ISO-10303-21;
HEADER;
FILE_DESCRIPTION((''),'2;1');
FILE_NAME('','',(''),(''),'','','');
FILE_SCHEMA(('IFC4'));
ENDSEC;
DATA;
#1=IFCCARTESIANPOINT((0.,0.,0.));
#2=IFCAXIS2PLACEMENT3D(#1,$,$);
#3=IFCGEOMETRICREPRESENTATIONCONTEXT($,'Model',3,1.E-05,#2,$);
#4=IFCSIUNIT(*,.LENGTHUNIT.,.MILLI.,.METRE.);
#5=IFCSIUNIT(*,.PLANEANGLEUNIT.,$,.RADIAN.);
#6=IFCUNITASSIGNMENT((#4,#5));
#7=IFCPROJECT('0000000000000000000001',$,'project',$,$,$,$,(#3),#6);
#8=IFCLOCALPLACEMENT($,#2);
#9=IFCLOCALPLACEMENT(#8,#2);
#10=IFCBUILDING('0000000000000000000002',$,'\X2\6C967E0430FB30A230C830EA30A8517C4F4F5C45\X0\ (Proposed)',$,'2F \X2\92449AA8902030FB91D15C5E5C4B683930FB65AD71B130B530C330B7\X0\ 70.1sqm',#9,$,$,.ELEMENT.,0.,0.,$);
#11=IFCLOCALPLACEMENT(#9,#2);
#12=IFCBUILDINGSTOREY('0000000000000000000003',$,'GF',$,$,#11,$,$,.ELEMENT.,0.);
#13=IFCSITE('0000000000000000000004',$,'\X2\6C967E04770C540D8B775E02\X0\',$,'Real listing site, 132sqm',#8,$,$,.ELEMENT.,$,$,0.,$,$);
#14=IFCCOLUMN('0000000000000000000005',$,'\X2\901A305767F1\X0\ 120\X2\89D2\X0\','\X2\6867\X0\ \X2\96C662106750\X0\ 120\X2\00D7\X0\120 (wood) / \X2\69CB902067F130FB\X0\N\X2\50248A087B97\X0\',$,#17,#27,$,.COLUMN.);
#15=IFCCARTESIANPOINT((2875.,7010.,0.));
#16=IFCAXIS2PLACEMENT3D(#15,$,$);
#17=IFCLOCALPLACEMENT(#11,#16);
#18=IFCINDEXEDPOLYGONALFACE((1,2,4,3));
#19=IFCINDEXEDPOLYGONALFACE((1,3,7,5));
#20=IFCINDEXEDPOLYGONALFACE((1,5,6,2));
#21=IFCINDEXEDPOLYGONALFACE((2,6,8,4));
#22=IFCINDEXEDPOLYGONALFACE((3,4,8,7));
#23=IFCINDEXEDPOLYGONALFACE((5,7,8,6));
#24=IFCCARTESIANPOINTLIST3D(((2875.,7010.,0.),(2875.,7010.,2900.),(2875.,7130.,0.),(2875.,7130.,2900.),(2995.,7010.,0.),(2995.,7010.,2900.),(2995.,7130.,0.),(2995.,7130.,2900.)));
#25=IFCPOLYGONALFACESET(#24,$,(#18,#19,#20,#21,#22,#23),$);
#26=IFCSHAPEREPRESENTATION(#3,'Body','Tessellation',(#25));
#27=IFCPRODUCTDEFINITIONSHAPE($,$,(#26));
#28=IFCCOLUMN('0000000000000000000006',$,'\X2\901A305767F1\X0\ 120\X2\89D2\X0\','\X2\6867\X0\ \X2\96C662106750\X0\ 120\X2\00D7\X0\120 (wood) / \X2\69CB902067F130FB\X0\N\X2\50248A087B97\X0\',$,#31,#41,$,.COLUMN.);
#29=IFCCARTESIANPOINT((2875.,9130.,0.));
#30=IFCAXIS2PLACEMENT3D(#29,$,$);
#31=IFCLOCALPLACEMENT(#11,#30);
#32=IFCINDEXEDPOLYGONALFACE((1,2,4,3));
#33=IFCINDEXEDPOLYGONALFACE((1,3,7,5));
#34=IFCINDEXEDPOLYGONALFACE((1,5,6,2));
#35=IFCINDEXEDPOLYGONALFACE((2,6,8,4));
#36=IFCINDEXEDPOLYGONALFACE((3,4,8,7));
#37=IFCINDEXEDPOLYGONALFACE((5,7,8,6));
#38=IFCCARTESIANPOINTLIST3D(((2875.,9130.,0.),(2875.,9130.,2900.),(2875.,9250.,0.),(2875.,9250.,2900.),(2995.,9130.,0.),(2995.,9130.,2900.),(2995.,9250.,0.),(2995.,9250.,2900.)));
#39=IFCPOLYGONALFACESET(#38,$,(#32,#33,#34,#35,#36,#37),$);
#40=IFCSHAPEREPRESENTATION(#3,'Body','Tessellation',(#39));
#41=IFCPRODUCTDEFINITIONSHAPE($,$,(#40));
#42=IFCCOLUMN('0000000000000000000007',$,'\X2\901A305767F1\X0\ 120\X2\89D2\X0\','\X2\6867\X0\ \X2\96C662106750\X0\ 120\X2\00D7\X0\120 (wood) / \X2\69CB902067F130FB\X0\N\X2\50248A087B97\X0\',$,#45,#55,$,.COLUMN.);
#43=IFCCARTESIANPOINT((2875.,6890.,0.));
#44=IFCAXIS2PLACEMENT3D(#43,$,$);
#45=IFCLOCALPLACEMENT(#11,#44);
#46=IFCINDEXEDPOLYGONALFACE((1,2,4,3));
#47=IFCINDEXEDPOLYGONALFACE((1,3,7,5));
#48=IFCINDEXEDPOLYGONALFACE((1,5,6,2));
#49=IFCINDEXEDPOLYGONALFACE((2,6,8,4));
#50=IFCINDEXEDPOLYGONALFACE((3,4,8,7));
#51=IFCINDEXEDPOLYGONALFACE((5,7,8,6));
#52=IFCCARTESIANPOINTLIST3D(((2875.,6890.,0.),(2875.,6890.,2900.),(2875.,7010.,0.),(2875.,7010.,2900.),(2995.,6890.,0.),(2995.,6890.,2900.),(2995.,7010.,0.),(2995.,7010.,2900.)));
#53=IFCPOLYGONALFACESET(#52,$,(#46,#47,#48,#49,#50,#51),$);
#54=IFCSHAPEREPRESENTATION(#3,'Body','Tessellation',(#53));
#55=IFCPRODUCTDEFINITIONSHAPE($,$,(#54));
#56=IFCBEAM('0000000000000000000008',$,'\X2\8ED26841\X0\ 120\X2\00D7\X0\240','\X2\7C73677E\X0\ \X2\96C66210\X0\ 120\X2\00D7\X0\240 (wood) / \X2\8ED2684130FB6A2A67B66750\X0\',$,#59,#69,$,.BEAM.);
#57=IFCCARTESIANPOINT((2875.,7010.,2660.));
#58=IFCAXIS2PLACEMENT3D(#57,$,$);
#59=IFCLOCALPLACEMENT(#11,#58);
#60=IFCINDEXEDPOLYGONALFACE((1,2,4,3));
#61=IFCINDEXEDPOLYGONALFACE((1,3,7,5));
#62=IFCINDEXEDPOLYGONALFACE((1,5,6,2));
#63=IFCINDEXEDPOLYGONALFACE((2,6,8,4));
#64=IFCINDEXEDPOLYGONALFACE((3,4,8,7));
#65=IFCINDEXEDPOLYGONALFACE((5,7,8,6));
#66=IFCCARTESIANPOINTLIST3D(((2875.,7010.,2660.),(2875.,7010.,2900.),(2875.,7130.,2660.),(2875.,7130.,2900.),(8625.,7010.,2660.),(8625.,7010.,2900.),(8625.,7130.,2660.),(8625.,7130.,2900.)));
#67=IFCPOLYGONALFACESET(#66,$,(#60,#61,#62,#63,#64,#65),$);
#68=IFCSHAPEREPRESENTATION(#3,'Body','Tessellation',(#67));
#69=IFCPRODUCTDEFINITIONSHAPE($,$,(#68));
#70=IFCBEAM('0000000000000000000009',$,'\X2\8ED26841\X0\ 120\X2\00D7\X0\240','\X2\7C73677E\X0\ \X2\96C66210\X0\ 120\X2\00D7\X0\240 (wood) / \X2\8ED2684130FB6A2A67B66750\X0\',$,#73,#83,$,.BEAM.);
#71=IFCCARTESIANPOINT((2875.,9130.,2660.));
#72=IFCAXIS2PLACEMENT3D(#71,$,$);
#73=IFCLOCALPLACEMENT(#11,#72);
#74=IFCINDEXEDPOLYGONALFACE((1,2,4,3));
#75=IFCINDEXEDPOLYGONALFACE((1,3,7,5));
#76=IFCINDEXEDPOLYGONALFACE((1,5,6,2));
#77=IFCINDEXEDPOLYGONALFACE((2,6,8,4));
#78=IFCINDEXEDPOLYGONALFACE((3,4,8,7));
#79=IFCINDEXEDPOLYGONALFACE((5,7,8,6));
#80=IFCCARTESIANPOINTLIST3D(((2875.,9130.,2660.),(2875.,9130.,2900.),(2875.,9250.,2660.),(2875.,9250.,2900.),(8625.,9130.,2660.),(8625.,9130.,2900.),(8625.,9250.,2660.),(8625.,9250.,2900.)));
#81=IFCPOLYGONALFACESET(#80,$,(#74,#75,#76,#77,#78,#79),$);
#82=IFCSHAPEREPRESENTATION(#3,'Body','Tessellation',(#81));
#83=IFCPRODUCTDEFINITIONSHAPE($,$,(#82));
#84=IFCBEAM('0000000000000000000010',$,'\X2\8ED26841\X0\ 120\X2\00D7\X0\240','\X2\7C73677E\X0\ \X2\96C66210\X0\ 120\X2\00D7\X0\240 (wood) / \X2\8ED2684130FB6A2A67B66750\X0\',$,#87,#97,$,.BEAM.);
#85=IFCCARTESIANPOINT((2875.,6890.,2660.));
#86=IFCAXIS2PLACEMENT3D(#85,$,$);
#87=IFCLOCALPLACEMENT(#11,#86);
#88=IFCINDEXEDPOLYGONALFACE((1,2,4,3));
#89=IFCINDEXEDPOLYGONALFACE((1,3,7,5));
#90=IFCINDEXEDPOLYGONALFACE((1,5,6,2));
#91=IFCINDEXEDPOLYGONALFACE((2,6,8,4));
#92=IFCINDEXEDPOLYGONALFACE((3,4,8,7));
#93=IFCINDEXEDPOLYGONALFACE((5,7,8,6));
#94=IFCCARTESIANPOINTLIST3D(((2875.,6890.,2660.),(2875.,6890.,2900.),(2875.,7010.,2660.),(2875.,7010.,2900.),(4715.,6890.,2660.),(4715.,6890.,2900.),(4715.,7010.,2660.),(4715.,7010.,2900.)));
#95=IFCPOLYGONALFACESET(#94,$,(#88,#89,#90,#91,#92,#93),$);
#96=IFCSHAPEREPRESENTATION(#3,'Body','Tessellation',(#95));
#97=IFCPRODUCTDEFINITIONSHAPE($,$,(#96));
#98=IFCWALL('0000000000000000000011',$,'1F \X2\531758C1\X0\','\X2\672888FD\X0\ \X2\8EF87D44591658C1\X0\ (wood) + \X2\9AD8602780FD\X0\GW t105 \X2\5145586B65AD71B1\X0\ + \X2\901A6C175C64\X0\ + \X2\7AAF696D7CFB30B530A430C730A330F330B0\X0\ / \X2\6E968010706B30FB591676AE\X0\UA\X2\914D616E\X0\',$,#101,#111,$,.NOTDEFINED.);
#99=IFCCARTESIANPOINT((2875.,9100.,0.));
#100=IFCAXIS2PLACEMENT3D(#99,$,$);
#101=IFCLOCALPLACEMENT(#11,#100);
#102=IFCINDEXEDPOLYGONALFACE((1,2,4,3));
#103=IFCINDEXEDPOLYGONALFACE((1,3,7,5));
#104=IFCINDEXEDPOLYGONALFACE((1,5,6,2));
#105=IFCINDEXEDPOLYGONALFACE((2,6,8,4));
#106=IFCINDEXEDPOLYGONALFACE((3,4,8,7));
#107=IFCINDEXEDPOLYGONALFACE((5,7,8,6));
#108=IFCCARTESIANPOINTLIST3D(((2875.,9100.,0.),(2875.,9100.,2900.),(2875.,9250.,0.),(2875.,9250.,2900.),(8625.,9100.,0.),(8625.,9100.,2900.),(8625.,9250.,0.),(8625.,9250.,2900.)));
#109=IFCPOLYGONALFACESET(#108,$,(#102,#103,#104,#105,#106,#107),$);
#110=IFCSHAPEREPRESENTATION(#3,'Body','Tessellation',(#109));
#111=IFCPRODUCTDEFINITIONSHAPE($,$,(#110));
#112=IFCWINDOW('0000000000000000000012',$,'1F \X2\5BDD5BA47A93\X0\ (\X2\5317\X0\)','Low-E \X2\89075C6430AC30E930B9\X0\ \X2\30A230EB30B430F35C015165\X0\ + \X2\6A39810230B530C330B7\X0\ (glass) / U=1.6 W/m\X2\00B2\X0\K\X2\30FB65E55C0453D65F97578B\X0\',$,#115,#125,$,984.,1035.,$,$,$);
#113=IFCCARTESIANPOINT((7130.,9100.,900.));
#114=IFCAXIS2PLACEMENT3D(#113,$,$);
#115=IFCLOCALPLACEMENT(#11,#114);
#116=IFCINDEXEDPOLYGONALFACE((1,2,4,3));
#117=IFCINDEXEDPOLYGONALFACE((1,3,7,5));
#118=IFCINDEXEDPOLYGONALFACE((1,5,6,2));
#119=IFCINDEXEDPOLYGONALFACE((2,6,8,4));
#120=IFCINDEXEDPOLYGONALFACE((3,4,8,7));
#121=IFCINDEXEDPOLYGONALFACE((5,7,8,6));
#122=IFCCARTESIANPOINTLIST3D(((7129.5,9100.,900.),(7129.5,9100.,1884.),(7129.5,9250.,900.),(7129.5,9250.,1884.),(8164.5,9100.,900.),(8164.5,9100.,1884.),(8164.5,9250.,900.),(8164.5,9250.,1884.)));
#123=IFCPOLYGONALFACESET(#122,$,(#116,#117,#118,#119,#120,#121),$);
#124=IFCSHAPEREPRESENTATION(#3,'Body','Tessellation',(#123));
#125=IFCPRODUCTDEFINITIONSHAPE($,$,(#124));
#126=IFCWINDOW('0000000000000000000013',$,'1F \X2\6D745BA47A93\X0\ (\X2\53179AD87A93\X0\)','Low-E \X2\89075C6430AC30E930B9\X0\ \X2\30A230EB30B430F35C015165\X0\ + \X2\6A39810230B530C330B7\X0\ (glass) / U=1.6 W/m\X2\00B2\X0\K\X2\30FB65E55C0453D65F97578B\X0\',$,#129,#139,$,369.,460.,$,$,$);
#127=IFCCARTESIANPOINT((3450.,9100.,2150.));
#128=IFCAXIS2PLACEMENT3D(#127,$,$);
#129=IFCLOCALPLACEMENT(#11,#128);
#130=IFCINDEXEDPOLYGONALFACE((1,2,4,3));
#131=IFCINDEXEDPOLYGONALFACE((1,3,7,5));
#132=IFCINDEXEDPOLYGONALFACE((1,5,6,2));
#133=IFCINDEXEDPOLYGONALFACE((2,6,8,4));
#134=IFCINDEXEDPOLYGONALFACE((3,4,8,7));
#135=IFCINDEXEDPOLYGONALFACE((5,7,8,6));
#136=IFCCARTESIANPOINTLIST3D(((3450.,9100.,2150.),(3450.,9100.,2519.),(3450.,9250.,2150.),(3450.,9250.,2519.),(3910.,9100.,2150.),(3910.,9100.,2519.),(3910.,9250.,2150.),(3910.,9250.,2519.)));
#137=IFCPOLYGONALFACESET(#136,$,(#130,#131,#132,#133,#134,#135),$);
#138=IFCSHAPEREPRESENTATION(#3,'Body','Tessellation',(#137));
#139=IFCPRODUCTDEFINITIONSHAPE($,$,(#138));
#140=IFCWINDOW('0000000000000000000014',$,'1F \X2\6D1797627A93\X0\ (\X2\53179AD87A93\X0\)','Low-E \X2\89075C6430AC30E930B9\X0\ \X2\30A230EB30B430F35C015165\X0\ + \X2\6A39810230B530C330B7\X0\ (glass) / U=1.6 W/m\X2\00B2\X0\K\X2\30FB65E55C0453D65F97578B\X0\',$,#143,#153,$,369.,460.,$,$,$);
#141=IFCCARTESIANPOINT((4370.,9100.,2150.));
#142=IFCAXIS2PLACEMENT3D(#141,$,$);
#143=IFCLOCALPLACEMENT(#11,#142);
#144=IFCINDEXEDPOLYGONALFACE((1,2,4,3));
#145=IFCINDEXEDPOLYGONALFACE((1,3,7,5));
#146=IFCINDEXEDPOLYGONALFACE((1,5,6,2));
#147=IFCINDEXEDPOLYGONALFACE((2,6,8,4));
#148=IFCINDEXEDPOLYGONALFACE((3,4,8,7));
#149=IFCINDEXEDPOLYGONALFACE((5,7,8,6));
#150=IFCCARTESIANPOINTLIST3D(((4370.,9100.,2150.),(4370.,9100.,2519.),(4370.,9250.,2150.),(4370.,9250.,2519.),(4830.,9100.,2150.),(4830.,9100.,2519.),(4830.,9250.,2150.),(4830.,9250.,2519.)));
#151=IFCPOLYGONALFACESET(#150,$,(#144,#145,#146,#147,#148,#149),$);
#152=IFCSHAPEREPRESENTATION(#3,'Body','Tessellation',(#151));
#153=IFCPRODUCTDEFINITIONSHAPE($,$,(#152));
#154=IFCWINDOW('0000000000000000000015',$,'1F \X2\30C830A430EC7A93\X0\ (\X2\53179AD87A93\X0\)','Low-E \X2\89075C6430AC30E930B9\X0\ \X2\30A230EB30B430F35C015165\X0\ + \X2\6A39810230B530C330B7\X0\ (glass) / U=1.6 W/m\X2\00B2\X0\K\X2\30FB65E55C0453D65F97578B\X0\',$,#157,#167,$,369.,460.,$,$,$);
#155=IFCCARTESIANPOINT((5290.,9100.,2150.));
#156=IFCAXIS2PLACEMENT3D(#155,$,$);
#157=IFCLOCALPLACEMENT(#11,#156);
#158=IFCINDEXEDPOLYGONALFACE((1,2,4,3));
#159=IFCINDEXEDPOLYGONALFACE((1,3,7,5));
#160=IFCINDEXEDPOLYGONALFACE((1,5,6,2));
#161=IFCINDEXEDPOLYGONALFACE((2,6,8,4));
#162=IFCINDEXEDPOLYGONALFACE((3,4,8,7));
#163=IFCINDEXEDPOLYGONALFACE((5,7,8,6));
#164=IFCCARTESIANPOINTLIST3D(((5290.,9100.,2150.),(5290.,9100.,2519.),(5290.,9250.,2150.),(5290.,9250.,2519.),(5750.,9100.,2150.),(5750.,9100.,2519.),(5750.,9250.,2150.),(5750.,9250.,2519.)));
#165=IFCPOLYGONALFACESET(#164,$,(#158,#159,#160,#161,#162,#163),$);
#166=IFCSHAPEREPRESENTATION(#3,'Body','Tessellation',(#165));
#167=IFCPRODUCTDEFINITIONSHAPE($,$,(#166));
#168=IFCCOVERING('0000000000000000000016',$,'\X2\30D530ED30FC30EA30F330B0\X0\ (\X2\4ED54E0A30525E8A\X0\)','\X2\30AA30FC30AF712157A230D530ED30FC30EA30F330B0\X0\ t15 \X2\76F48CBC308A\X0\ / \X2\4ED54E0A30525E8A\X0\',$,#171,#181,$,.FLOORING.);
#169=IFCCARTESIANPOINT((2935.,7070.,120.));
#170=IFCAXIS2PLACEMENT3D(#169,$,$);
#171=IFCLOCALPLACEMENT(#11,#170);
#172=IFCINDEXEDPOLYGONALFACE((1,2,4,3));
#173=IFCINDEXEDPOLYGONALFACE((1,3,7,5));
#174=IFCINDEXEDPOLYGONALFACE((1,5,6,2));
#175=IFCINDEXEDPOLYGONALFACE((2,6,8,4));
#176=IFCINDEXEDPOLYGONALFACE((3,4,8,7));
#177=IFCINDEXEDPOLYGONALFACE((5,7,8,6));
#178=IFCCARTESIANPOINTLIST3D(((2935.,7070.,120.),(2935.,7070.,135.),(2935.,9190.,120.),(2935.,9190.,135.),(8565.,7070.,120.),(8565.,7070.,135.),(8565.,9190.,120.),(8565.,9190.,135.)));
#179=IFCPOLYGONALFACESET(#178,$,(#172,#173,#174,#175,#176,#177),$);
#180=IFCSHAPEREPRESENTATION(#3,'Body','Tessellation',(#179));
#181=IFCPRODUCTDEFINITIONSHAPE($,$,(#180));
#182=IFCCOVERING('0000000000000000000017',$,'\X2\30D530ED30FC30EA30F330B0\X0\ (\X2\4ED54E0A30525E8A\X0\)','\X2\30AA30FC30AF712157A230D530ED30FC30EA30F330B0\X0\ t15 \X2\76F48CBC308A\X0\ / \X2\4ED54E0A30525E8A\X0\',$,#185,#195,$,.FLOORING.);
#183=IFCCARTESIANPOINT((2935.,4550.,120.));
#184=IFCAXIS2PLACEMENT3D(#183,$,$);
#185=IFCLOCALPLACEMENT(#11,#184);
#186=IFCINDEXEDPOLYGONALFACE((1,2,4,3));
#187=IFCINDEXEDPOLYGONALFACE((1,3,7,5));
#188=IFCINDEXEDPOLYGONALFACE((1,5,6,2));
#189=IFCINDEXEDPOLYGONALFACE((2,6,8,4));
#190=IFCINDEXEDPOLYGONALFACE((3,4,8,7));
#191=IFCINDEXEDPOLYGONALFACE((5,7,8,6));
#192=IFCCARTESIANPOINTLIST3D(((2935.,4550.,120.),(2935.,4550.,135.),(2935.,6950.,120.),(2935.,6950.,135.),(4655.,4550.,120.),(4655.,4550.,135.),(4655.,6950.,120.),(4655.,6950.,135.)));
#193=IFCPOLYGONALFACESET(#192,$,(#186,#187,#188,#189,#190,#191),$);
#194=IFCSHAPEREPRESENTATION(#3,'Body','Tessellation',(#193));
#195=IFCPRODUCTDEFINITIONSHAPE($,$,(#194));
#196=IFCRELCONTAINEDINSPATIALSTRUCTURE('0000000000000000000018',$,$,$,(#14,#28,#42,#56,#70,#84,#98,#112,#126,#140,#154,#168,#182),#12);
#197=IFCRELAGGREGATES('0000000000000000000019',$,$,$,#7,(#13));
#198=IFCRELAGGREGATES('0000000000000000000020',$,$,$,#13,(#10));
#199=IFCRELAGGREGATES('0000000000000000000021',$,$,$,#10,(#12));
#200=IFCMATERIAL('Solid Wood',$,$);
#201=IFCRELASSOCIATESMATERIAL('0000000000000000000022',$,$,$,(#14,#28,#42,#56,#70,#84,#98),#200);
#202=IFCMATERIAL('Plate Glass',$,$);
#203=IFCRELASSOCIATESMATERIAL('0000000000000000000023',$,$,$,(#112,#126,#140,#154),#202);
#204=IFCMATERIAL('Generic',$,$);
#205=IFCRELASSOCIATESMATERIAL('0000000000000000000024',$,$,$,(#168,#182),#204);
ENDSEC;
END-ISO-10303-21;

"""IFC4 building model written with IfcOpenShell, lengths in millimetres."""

from ifc_helpers import new_model, si_unit, frame, frame_2d, origin, place, context, project, spatial, rectangle, extrude, material, element, fill, save


model = new_model("IFC4")

# Units and contexts
model_context = context("Model", 3, precision=1e-05, world=origin())
ifc_project = project(units=[si_unit("LENGTHUNIT", "METRE", prefix="MILLI"), si_unit("PLANEANGLEUNIT", "RADIAN")], contexts=[model_context])

# Site, building, storey
site_placement = place(None, origin())
site = spatial("IfcSite", under=ifc_project, at=site_placement, Name="沖縄県名護市", ObjectType="Real listing site, 132sqm", CompositionType="ELEMENT", RefElevation=0.0)
building_placement = place(site_placement, origin())
building = spatial("IfcBuilding", under=site, at=building_placement, Name="沖縄・アトリエ兼住居 (Proposed)", ObjectType="2F 鉄骨造・金属屋根・断熱サッシ 70.1sqm", CompositionType="ELEMENT", ElevationOfRefHeight=0.0, ElevationOfTerrain=0.0)
storey_placement = place(building_placement, origin())
storey = spatial("IfcBuildingStorey", under=building, at=storey_placement, Name="GF", CompositionType="ELEMENT", Elevation=0.0)

# Columns
ifc_material_1 = material(Name="Solid Wood")
column_1_placement = place(storey_placement, frame((2875.0, 7010.0, 0.0)))
element("IfcColumn", 1, at=column_1_placement, inside=storey, material=ifc_material_1, Name="通し柱 120角", Description="桧 集成材 120×120 (wood) / 構造柱・N値計算", PredefinedType="COLUMN", context=model_context, shape_type="SweptSolid", body=[
    extrude(rectangle(XDim=120.0, YDim=120.0, at=frame_2d((60.0, 60.0))), frame((2875.0, 7010.0, 0.0)), (0.0, 0.0, 1.0), 2900.0),
])
column_2_placement = place(storey_placement, frame((2875.0, 9130.0, 0.0)))
element("IfcColumn", 2, at=column_2_placement, inside=storey, material=ifc_material_1, Name="通し柱 120角", Description="桧 集成材 120×120 (wood) / 構造柱・N値計算", PredefinedType="COLUMN", context=model_context, shape_type="SweptSolid", body=[
    extrude(rectangle(XDim=120.0, YDim=120.0, at=frame_2d((60.0, 60.0))), frame((2875.0, 9130.0, 0.0)), (0.0, 0.0, 1.0), 2900.0),
])
column_3_placement = place(storey_placement, frame((2875.0, 6890.0, 0.0)))
element("IfcColumn", 3, at=column_3_placement, inside=storey, material=ifc_material_1, Name="通し柱 120角", Description="桧 集成材 120×120 (wood) / 構造柱・N値計算", PredefinedType="COLUMN", context=model_context, shape_type="SweptSolid", body=[
    extrude(rectangle(XDim=120.0, YDim=120.0, at=frame_2d((60.0, 60.0))), frame((2875.0, 6890.0, 0.0)), (0.0, 0.0, 1.0), 2900.0),
])

# Beams
beam_1_placement = place(storey_placement, frame((2875.0, 7010.0, 2660.0)))
element("IfcBeam", 4, at=beam_1_placement, inside=storey, material=ifc_material_1, Name="軒桁 120×240", Description="米松 集成 120×240 (wood) / 軒桁・横架材", PredefinedType="BEAM", context=model_context, shape_type="SweptSolid", body=[
    extrude(rectangle(XDim=5750.0, YDim=120.0, at=frame_2d((2875.0, 60.0))), frame((2875.0, 7010.0, 2660.0)), (0.0, 0.0, 1.0), 240.0),
])
beam_2_placement = place(storey_placement, frame((2875.0, 9130.0, 2660.0)))
element("IfcBeam", 5, at=beam_2_placement, inside=storey, material=ifc_material_1, Name="軒桁 120×240", Description="米松 集成 120×240 (wood) / 軒桁・横架材", PredefinedType="BEAM", context=model_context, shape_type="SweptSolid", body=[
    extrude(rectangle(XDim=5750.0, YDim=120.0, at=frame_2d((2875.0, 60.0))), frame((2875.0, 9130.0, 2660.0)), (0.0, 0.0, 1.0), 240.0),
])
beam_3_placement = place(storey_placement, frame((2875.0, 6890.0, 2660.0)))
element("IfcBeam", 6, at=beam_3_placement, inside=storey, material=ifc_material_1, Name="軒桁 120×240", Description="米松 集成 120×240 (wood) / 軒桁・横架材", PredefinedType="BEAM", context=model_context, shape_type="SweptSolid", body=[
    extrude(rectangle(XDim=1840.0, YDim=120.0, at=frame_2d((920.0, 60.0))), frame((2875.0, 6890.0, 2660.0)), (0.0, 0.0, 1.0), 240.0),
])

# Wall, openings, windows
wall_1_placement = place(storey_placement, frame((2875.0, 9100.0, 0.0)))
wall_1 = element("IfcWall", 7, at=wall_1_placement, inside=storey, material=ifc_material_1, Name="1F 北壁", Description="木製 軸組外壁 (wood) + 高性能GW t105 充填断熱 + 通気層 + 窯業系サイディング / 準耐火・外皮UA配慮", PredefinedType="NOTDEFINED", context=model_context, shape_type="SweptSolid", body=[
    extrude(rectangle(XDim=5750.0, YDim=150.0, at=frame_2d((2875.0, 75.0))), frame((2875.0, 9100.0, 0.0)), (0.0, 0.0, 1.0), 2900.0),
])
opening_1_placement = place(storey_placement, frame((7130.0, 9100.0, 900.0)))
opening_1 = element("IfcOpeningElement", 8, at=opening_1_placement, cuts=wall_1, PredefinedType="NOTDEFINED", context=model_context, shape_type="SweptSolid", body=[
    extrude(rectangle(XDim=1035.0, YDim=150.0, at=frame_2d((517.0, 75.0))), frame((7130.0, 9100.0, 900.0)), (0.0, 0.0, 1.0), 984.0),
])
opening_2_placement = place(storey_placement, frame((3450.0, 9100.0, 2150.0)))
opening_2 = element("IfcOpeningElement", 9, at=opening_2_placement, cuts=wall_1, PredefinedType="NOTDEFINED", context=model_context, shape_type="SweptSolid", body=[
    extrude(rectangle(XDim=460.0, YDim=150.0, at=frame_2d((230.0, 75.0))), frame((3450.0, 9100.0, 2150.0)), (0.0, 0.0, 1.0), 369.0),
])
opening_3_placement = place(storey_placement, frame((4370.0, 9100.0, 2150.0)))
opening_3 = element("IfcOpeningElement", 10, at=opening_3_placement, cuts=wall_1, PredefinedType="NOTDEFINED", context=model_context, shape_type="SweptSolid", body=[
    extrude(rectangle(XDim=460.0, YDim=150.0, at=frame_2d((230.0, 75.0))), frame((4370.0, 9100.0, 2150.0)), (0.0, 0.0, 1.0), 369.0),
])
opening_4_placement = place(storey_placement, frame((5290.0, 9100.0, 2150.0)))
opening_4 = element("IfcOpeningElement", 11, at=opening_4_placement, cuts=wall_1, PredefinedType="NOTDEFINED", context=model_context, shape_type="SweptSolid", body=[
    extrude(rectangle(XDim=460.0, YDim=150.0, at=frame_2d((230.0, 75.0))), frame((5290.0, 9100.0, 2150.0)), (0.0, 0.0, 1.0), 369.0),
])
ifc_material_2 = material(Name="Plate Glass")
window_1_placement = place(storey_placement, frame((7130.0, 9100.0, 900.0)))
window_1 = element("IfcWindow", 12, at=window_1_placement, inside=storey, material=ifc_material_2, Name="1F 寝室窓 (北)", Description="Low-E 複層ガラス アルゴン封入 + 樹脂サッシ (glass) / U=1.6 W/m²K・日射取得型", OverallHeight=984.0, OverallWidth=1035.0, context=model_context, shape_type="SweptSolid", body=[
    extrude(rectangle(XDim=1035.0, YDim=150.0, at=frame_2d((517.0, 75.0))), frame((7130.0, 9100.0, 900.0)), (0.0, 0.0, 1.0), 984.0),
])
fill(opening_1, window_1)
window_2_placement = place(storey_placement, frame((3450.0, 9100.0, 2150.0)))
window_2 = element("IfcWindow", 13, at=window_2_placement, inside=storey, material=ifc_material_2, Name="1F 浴室窓 (北高窓)", Description="Low-E 複層ガラス アルゴン封入 + 樹脂サッシ (glass) / U=1.6 W/m²K・日射取得型", OverallHeight=369.0, OverallWidth=460.0, context=model_context, shape_type="SweptSolid", body=[
    extrude(rectangle(XDim=460.0, YDim=150.0, at=frame_2d((230.0, 75.0))), frame((3450.0, 9100.0, 2150.0)), (0.0, 0.0, 1.0), 369.0),
])
fill(opening_2, window_2)
window_3_placement = place(storey_placement, frame((4370.0, 9100.0, 2150.0)))
window_3 = element("IfcWindow", 14, at=window_3_placement, inside=storey, material=ifc_material_2, Name="1F 洗面窓 (北高窓)", Description="Low-E 複層ガラス アルゴン封入 + 樹脂サッシ (glass) / U=1.6 W/m²K・日射取得型", OverallHeight=369.0, OverallWidth=460.0, context=model_context, shape_type="SweptSolid", body=[
    extrude(rectangle(XDim=460.0, YDim=150.0, at=frame_2d((230.0, 75.0))), frame((4370.0, 9100.0, 2150.0)), (0.0, 0.0, 1.0), 369.0),
])
fill(opening_3, window_3)
window_4_placement = place(storey_placement, frame((5290.0, 9100.0, 2150.0)))
window_4 = element("IfcWindow", 15, at=window_4_placement, inside=storey, material=ifc_material_2, Name="1F トイレ窓 (北高窓)", Description="Low-E 複層ガラス アルゴン封入 + 樹脂サッシ (glass) / U=1.6 W/m²K・日射取得型", OverallHeight=369.0, OverallWidth=460.0, context=model_context, shape_type="SweptSolid", body=[
    extrude(rectangle(XDim=460.0, YDim=150.0, at=frame_2d((230.0, 75.0))), frame((5290.0, 9100.0, 2150.0)), (0.0, 0.0, 1.0), 369.0),
])
fill(opening_4, window_4)

# Coverings
ifc_material_3 = material(Name="Generic")
covering_1_placement = place(storey_placement, frame((2935.0, 7070.0, 120.0)))
element("IfcCovering", 16, at=covering_1_placement, inside=storey, material=ifc_material_3, Name="フローリング (仕上げ床)", Description="オーク無垢フローリング t15 直貼り / 仕上げ床", PredefinedType="FLOORING", context=model_context, shape_type="SweptSolid", body=[
    extrude(rectangle(XDim=5630.0, YDim=2120.0, at=frame_2d((2815.0, 1060.0))), frame((2935.0, 7070.0, 120.0)), (0.0, 0.0, 1.0), 15.0),
])
covering_2_placement = place(storey_placement, frame((2935.0, 4550.0, 120.0)))
element("IfcCovering", 17, at=covering_2_placement, inside=storey, material=ifc_material_3, Name="フローリング (仕上げ床)", Description="オーク無垢フローリング t15 直貼り / 仕上げ床", PredefinedType="FLOORING", context=model_context, shape_type="SweptSolid", body=[
    extrude(rectangle(XDim=1720.0, YDim=2400.0, at=frame_2d((860.0, 1200.0))), frame((2935.0, 4550.0, 120.0)), (0.0, 0.0, 1.0), 15.0),
])

save(model, "model.ifc")
